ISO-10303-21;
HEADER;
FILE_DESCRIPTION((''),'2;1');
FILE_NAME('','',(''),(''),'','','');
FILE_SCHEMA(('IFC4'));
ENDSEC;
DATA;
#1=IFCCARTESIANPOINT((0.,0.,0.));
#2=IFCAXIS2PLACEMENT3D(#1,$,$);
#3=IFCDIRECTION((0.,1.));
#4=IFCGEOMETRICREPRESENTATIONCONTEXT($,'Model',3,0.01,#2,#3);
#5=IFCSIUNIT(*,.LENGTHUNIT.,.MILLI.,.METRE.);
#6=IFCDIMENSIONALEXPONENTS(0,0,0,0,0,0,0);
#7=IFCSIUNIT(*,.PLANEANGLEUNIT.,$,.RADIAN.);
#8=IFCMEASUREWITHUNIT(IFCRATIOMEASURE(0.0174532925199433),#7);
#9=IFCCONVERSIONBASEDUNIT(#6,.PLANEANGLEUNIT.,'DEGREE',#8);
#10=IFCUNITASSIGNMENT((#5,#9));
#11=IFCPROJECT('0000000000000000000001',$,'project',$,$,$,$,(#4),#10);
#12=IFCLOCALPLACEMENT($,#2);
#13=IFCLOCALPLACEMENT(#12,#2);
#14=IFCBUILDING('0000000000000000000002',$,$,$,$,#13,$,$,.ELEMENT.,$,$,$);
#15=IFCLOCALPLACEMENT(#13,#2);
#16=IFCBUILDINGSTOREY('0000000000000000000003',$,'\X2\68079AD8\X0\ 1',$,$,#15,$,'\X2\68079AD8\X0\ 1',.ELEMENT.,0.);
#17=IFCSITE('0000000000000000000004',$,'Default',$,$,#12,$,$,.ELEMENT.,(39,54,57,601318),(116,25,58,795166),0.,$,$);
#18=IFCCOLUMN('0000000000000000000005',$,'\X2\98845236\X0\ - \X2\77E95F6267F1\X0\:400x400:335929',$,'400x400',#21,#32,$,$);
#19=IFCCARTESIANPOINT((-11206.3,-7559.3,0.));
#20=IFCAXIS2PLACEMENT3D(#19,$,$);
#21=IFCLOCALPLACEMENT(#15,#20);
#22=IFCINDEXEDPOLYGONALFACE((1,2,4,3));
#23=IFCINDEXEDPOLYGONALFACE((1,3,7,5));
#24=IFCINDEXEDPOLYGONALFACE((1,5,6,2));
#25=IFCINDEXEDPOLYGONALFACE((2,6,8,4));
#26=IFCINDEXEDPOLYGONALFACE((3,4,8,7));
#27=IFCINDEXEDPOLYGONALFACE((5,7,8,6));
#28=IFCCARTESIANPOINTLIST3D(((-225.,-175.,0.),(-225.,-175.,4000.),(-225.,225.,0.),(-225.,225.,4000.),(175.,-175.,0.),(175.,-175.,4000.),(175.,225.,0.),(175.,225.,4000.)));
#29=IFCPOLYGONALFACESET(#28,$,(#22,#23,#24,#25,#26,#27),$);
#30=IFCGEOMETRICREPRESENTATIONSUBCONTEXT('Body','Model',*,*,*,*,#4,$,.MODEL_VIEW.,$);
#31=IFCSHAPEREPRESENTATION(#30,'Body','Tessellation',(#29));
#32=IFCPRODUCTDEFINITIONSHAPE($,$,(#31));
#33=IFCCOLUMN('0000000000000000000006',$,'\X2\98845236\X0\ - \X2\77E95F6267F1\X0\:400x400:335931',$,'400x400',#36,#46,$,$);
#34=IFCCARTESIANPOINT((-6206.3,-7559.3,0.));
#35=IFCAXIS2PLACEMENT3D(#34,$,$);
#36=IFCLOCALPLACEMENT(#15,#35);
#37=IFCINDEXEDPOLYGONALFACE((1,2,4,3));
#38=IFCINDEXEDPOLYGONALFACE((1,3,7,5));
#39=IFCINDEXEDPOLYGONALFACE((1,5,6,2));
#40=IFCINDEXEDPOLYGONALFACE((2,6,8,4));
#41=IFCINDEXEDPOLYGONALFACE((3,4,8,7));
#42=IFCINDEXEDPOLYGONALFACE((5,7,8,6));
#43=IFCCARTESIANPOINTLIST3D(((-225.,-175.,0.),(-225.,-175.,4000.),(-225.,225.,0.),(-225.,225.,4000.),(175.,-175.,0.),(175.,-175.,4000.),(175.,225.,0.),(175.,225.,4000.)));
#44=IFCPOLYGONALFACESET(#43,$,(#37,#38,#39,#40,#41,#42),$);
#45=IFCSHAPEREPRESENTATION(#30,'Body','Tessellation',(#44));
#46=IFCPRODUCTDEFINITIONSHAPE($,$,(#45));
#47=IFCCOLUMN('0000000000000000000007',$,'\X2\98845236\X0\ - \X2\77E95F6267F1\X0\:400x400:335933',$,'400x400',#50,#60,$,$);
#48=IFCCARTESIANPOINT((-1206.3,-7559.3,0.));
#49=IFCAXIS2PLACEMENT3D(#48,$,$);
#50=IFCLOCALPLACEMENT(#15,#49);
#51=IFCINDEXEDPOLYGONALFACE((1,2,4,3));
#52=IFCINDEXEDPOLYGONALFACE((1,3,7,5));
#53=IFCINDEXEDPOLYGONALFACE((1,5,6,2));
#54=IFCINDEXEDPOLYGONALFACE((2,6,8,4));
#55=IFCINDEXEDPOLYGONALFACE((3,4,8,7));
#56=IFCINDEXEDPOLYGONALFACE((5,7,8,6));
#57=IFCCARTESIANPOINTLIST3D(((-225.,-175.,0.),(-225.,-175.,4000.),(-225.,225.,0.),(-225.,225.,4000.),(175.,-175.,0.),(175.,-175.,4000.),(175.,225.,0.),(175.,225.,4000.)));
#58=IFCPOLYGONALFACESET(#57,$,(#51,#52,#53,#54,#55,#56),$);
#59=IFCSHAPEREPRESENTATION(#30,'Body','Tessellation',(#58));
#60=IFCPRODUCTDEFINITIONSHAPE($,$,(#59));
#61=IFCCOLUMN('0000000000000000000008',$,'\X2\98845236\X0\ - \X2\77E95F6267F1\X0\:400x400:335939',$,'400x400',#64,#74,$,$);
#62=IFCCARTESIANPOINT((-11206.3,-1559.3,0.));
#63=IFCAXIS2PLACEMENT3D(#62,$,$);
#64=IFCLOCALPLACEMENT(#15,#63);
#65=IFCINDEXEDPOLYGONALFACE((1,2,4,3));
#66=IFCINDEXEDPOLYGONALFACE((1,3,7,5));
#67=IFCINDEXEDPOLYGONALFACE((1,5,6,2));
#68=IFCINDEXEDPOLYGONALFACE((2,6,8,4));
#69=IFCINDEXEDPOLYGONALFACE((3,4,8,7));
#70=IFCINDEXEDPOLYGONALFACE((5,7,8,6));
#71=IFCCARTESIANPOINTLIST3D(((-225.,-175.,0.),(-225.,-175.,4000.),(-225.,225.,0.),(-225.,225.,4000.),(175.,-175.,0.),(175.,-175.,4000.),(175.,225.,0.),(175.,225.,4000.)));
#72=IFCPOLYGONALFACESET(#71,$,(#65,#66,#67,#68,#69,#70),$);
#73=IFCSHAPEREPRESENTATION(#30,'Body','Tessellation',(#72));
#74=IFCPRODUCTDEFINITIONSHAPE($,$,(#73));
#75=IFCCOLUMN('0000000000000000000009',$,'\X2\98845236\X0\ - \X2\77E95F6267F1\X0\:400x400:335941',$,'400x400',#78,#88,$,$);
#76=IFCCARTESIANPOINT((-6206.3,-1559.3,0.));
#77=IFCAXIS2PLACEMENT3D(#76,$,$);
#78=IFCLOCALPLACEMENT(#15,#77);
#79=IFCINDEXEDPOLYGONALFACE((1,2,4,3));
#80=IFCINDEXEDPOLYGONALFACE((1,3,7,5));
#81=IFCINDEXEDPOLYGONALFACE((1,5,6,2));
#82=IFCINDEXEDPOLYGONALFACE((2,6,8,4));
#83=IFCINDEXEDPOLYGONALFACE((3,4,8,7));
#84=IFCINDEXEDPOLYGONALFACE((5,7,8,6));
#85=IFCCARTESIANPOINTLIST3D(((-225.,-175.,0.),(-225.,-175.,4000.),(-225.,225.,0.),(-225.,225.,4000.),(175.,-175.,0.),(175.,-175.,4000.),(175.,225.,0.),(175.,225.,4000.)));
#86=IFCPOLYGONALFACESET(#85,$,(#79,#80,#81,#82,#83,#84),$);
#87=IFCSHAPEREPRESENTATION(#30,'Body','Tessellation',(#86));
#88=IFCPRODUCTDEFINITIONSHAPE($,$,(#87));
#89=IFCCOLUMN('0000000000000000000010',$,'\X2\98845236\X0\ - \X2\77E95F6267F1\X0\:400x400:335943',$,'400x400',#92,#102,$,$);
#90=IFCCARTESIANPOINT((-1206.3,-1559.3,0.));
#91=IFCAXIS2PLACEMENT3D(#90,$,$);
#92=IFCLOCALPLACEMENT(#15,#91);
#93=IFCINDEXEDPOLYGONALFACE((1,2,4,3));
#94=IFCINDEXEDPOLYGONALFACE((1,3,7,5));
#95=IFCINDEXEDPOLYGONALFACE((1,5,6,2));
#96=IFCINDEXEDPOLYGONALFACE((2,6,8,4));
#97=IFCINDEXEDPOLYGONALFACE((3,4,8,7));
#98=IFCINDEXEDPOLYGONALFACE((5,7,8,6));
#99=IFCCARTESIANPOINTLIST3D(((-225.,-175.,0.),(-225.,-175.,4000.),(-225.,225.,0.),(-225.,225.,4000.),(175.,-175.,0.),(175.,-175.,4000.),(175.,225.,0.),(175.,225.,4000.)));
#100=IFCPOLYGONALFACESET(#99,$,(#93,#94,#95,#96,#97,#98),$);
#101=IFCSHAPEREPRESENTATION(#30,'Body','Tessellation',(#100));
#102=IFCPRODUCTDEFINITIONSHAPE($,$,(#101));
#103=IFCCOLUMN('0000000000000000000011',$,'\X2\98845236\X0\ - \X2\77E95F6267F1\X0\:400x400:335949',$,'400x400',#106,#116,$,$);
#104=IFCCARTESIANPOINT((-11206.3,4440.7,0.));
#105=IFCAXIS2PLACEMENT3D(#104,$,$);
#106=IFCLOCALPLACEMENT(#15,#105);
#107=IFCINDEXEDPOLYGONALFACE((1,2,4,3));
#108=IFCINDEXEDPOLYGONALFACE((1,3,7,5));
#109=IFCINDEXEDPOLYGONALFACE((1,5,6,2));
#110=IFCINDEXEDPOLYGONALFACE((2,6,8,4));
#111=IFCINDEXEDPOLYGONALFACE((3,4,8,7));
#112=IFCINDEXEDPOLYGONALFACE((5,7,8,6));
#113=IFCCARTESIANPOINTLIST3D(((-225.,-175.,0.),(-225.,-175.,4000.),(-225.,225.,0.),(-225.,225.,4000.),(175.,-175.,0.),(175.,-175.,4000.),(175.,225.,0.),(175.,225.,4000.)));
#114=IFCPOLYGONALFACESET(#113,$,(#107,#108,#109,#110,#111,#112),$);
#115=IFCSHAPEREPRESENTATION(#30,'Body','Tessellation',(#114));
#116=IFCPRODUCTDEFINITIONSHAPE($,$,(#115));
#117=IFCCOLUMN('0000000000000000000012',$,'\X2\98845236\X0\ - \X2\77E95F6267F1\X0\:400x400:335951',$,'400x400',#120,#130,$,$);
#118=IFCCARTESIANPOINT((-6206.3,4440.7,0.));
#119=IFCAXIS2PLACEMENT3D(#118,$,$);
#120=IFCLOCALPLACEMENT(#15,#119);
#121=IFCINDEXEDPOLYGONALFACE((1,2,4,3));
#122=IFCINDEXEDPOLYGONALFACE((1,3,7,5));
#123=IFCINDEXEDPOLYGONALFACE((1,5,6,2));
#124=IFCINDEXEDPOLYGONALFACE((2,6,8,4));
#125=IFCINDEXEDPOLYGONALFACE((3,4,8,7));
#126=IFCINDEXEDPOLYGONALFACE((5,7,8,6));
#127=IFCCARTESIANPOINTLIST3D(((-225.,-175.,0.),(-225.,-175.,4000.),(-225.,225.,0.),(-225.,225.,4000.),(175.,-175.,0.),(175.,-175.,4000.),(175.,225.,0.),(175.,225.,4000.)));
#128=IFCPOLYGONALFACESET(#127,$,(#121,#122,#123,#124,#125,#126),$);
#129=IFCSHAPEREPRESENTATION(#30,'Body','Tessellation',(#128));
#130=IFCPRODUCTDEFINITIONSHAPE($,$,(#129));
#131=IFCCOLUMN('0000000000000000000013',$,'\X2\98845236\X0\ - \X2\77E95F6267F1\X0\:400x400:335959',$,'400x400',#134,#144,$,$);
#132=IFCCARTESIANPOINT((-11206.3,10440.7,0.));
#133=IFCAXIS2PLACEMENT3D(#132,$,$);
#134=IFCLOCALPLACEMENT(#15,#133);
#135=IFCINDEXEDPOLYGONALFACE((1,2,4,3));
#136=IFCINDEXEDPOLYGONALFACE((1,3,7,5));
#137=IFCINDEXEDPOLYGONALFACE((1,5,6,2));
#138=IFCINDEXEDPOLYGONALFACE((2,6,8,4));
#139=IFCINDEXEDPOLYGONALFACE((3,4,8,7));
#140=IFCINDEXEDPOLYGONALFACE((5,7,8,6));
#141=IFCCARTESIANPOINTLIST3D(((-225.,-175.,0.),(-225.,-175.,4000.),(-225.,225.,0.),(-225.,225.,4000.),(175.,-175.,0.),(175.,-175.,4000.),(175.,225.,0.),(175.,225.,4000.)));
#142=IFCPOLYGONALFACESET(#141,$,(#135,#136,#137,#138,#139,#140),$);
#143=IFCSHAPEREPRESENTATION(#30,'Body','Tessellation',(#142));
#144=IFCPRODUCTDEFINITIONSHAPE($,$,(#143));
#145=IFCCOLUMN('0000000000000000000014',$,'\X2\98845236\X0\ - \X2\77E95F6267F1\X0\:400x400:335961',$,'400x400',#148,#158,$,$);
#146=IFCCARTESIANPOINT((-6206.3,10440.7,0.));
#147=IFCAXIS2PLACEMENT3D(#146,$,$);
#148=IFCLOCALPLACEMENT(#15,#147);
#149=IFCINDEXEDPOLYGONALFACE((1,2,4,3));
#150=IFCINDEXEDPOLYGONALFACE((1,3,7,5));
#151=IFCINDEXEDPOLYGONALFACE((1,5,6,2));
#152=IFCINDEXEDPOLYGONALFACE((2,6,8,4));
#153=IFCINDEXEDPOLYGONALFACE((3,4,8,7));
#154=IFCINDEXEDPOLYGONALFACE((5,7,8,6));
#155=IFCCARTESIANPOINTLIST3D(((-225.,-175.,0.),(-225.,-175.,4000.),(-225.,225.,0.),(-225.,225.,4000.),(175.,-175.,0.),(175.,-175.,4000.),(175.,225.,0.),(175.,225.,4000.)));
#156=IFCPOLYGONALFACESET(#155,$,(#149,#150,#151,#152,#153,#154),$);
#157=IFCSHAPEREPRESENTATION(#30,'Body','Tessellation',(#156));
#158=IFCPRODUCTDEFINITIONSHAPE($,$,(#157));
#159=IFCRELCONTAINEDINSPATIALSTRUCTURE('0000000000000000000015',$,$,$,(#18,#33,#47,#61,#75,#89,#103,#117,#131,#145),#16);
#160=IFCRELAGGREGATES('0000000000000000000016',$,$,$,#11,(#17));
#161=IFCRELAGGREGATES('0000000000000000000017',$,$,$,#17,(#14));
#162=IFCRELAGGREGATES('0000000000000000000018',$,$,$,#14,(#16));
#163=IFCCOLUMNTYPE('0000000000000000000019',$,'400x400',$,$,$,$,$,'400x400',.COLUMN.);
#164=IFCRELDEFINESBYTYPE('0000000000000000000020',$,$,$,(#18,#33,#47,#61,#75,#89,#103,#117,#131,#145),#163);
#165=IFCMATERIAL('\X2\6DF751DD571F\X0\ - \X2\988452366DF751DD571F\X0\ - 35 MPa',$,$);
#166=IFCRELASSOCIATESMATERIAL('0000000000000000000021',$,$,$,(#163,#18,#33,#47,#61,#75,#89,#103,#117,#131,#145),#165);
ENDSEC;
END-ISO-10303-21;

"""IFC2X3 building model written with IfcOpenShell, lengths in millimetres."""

from ifc_helpers import new_model, entity, si_unit, converted_unit, direction, frame, frame_2d, origin, place, context, subcontext, project, spatial, rectangle, extrude, source, transform, mapped, material, type_object, type_shapes, element, save


model = new_model("IFC2X3")

# Units and contexts
model_context = context("Model", 3, precision=0.01, world=origin(), true_north=direction((0.0, 1.0)))
body_context = subcontext(model_context, "Body", "Model", "MODEL_VIEW")
ifc_project = project(units=[si_unit("LENGTHUNIT", "METRE", prefix="MILLI"), converted_unit("PLANEANGLEUNIT", "DEGREE", entity("IfcRatioMeasure", 0.0174532925199433), si_unit("PLANEANGLEUNIT", "RADIAN"), dimensions=[0, 0, 0, 0, 0, 0, 0])], contexts=[model_context])

# Site, building, storey
site_placement = place(None, origin())
site = spatial("IfcSite", under=ifc_project, at=site_placement, Name="Default", CompositionType="ELEMENT", RefLatitude=(39, 54, 57, 601318), RefLongitude=(116, 25, 58, 795166), RefElevation=0.0)
building_placement = place(site_placement, origin())
building = spatial("IfcBuilding", under=site, at=building_placement, CompositionType="ELEMENT")
storey_placement = place(building_placement, origin())
storey = spatial("IfcBuildingStorey", under=building, at=storey_placement, Name="标高 1", LongName="标高 1", CompositionType="ELEMENT", Elevation=0.0)

# Columns
ifc_material_1 = material(Name="混凝土 - 预制混凝土 - 35 MPa")
column_type = type_object("IfcColumnType", Name="400x400", ElementType="400x400", PredefinedType="COLUMN", material=ifc_material_1)
shared_shape_1 = source(origin(), body_context, "Body", "SweptSolid", [
    extrude(rectangle(XDim=400.0, YDim=400.0, at=frame_2d((0.0, 0.0), x_axis=(1.0, 0.0))), frame((-25.0, 25.0, 0.0)), (0.0, 0.0, 1.0), 4000.0),
])
type_shapes(column_type, [shared_shape_1])
for number, where, name in (
    (1, (-11206.3, -7559.3, 0.0), "预制 - 矩形柱:400x400:335929"),
    (2, (-6206.3, -7559.3, 0.0), "预制 - 矩形柱:400x400:335931"),
    (3, (-1206.3, -7559.3, 0.0), "预制 - 矩形柱:400x400:335933"),
    (4, (-11206.3, -1559.3, 0.0), "预制 - 矩形柱:400x400:335939"),
    (5, (-6206.3, -1559.3, 0.0), "预制 - 矩形柱:400x400:335941"),
    (6, (-1206.3, -1559.3, 0.0), "预制 - 矩形柱:400x400:335943"),
    (7, (-11206.3, 4440.7, 0.0), "预制 - 矩形柱:400x400:335949"),
    (8, (-6206.3, 4440.7, 0.0), "预制 - 矩形柱:400x400:335951"),
    (9, (-11206.3, 10440.7, 0.0), "预制 - 矩形柱:400x400:335959"),
    (10, (-6206.3, 10440.7, 0.0), "预制 - 矩形柱:400x400:335961"),
):
    element("IfcColumn", number, at=place(storey_placement, frame(where)), inside=storey, type_object=column_type, material=ifc_material_1, Name=name, ObjectType="400x400", context=body_context, shape_type="MappedRepresentation", body=[
        mapped(shared_shape_1, transform((0.0, 0.0, 0.0), scale=1.0)),
    ])

save(model, "model.ifc")
